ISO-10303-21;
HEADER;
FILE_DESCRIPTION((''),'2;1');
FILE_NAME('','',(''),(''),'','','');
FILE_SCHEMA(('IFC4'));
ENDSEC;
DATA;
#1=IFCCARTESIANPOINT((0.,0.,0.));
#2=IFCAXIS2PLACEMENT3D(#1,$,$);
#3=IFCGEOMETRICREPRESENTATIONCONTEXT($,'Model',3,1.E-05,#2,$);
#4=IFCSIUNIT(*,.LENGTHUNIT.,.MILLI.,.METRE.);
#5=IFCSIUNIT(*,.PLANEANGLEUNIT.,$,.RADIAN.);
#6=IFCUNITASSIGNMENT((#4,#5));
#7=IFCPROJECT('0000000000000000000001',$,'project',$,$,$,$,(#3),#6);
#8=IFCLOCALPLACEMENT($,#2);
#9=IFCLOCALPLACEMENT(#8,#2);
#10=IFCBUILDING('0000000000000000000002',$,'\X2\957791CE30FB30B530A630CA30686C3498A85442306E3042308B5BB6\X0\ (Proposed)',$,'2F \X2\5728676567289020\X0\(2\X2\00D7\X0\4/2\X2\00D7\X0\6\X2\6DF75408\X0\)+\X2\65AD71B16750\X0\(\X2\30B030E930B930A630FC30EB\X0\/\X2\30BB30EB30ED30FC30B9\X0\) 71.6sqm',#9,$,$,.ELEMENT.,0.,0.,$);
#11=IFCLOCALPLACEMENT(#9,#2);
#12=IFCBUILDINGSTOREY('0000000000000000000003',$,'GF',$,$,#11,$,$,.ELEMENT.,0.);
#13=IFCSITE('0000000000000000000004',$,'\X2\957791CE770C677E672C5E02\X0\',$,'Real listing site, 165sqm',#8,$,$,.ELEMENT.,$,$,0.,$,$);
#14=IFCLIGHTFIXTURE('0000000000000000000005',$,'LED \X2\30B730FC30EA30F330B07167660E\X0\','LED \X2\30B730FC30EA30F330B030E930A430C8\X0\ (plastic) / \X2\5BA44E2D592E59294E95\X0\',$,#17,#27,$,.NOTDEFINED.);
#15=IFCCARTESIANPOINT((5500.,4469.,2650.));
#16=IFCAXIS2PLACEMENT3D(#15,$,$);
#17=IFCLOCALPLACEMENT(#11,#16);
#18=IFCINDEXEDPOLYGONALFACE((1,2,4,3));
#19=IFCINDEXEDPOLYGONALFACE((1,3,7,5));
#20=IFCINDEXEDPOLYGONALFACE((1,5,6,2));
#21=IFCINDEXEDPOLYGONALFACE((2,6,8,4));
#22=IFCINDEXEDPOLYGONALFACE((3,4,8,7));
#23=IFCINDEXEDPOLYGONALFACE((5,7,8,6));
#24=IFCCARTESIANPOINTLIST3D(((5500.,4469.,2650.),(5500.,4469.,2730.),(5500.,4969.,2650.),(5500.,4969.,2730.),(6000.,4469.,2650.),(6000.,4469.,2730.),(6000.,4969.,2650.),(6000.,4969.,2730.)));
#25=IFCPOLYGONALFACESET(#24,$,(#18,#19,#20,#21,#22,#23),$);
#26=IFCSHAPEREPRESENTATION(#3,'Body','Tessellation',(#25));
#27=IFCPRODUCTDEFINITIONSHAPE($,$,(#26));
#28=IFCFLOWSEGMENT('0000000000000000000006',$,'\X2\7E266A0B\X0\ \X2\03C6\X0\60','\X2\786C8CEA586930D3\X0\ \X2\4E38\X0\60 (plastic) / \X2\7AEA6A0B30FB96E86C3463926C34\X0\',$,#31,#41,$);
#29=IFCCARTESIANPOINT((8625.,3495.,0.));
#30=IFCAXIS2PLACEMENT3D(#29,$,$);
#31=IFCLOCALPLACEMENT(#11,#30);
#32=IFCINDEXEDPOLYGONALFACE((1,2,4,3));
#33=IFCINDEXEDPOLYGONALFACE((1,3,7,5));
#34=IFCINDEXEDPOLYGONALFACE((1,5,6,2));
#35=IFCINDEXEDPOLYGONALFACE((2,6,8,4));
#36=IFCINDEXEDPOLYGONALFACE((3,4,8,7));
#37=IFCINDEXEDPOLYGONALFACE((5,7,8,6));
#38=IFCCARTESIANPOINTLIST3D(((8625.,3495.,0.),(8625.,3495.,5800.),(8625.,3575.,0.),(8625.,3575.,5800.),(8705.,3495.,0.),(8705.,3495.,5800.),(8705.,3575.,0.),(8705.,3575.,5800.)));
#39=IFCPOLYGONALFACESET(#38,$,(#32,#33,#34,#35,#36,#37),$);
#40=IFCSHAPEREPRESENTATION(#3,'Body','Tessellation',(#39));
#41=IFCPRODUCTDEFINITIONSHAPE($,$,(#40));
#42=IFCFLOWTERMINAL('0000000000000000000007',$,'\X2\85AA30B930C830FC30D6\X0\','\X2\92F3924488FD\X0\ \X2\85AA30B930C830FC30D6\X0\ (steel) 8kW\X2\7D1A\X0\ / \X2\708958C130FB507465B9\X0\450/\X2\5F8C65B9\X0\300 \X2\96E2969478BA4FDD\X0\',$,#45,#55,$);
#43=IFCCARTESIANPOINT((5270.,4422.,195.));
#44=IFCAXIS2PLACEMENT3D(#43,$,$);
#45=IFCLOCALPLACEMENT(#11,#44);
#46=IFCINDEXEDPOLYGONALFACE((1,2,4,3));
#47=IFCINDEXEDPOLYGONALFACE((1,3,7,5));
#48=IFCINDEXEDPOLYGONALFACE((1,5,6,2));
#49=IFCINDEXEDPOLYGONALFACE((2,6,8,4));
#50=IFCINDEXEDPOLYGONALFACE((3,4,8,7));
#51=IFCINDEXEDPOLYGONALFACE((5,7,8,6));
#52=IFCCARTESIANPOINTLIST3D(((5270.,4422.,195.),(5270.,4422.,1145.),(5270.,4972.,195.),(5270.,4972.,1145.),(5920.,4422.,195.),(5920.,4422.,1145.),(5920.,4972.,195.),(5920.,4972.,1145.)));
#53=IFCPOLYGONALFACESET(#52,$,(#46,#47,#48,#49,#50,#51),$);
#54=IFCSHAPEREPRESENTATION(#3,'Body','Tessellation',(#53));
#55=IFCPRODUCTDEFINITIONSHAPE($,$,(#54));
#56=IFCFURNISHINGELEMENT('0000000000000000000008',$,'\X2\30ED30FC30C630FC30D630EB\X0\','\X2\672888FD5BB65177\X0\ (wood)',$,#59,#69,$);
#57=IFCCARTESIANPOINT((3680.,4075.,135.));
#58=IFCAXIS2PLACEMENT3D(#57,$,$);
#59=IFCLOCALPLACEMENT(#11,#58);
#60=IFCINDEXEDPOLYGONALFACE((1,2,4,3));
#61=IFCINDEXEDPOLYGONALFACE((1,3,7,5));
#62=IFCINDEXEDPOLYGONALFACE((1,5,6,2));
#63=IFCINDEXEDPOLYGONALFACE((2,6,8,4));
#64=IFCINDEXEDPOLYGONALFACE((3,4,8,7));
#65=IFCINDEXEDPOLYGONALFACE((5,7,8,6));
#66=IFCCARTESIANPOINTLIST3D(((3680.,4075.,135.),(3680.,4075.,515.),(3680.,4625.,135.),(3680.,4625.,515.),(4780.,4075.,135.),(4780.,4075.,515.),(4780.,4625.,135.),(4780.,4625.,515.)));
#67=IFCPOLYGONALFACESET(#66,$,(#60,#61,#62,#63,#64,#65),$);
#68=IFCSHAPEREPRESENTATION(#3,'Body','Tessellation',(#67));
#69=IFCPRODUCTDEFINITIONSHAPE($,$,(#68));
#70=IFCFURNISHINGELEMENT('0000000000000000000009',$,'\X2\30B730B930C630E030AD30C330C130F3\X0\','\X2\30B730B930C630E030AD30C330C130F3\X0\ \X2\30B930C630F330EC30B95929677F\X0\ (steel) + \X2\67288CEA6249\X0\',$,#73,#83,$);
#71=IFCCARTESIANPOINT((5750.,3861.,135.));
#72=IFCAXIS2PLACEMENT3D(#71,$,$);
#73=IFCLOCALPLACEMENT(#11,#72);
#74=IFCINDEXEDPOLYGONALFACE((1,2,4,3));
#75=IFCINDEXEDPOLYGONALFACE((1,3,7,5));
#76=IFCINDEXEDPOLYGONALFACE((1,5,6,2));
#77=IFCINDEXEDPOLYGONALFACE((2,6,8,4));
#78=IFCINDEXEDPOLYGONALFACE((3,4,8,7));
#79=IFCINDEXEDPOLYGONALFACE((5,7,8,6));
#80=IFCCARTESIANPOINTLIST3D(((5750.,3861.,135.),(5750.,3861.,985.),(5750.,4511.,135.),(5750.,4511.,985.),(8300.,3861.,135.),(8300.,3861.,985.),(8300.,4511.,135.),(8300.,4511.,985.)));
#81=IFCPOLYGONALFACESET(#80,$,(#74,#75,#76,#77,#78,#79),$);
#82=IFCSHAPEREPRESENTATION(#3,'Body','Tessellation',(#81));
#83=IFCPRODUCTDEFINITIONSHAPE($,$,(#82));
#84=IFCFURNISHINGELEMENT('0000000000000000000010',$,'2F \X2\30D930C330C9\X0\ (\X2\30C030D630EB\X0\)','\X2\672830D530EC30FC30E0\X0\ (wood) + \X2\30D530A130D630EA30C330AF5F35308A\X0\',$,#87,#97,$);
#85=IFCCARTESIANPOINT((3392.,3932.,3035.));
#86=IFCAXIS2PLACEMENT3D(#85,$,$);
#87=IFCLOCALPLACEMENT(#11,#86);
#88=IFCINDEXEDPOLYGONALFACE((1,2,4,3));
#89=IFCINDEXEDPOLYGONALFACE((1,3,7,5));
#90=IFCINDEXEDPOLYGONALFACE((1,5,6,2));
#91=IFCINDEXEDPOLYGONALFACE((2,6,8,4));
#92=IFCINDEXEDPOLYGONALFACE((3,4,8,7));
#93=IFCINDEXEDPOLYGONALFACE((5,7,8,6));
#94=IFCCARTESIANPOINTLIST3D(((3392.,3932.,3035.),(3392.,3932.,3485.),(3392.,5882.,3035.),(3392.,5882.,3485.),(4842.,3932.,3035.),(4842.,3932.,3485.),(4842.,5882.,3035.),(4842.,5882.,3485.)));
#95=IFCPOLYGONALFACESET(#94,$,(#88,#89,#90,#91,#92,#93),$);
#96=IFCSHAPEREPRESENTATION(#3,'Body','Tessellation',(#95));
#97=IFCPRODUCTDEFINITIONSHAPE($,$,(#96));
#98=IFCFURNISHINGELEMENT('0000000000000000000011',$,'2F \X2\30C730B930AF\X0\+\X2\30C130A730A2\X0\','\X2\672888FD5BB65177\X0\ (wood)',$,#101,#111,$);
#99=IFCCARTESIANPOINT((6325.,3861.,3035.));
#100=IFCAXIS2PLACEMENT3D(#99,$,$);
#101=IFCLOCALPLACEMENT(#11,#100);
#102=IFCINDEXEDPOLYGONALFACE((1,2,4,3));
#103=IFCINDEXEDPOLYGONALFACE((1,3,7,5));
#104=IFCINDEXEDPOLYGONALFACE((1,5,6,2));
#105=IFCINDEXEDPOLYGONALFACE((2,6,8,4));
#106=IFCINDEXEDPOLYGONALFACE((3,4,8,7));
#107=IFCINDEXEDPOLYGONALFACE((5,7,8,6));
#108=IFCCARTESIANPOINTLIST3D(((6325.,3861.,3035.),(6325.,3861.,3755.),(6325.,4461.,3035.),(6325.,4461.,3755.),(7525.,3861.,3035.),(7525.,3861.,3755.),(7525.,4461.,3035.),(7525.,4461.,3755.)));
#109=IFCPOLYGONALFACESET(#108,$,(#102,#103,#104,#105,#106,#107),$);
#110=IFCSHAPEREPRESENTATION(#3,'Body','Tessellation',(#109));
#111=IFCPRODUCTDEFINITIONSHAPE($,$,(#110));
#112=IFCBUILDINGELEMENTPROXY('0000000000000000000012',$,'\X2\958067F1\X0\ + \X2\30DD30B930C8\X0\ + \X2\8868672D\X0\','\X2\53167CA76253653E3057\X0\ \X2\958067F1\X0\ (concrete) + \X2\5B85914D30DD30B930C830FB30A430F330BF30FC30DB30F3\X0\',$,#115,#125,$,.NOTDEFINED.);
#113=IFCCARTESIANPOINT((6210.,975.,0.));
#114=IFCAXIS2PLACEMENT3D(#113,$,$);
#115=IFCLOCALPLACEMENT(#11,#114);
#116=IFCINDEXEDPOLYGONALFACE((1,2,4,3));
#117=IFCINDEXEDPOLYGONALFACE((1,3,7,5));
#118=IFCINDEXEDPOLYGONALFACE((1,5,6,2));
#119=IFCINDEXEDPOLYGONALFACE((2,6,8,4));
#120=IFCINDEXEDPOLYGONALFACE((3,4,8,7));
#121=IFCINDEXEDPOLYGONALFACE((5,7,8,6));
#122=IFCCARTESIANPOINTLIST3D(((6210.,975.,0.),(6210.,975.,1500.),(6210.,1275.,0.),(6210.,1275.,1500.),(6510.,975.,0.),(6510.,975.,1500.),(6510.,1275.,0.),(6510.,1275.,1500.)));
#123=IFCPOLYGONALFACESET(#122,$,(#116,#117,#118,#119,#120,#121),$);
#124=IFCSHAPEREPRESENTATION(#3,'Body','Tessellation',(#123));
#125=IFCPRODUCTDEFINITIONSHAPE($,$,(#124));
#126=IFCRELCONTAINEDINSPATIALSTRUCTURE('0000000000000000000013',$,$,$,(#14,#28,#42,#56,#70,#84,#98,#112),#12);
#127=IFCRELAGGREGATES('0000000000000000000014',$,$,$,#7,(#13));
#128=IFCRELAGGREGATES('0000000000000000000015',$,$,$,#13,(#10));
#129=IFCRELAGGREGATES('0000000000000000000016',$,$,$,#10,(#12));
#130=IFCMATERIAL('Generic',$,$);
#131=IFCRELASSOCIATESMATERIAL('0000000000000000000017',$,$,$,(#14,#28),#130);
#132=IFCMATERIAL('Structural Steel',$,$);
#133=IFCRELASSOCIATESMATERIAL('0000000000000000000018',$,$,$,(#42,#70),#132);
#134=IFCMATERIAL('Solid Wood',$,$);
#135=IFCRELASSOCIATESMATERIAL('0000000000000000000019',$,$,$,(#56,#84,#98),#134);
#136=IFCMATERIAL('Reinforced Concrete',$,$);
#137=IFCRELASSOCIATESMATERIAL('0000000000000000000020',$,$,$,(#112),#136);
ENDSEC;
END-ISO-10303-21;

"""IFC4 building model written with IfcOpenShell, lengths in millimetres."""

from ifc_helpers import new_model, si_unit, frame, frame_2d, origin, place, context, project, spatial, rectangle, extrude, material, element, save


model = new_model("IFC4")

# Units and contexts
model_context = context("Model", 3, precision=1e-05, world=origin())
ifc_project = project(units=[si_unit("LENGTHUNIT", "METRE", prefix="MILLI"), si_unit("PLANEANGLEUNIT", "RADIAN")], contexts=[model_context])

# Site, building, storey
site_placement = place(None, origin())
site = spatial("IfcSite", under=ifc_project, at=site_placement, Name="長野県松本市", ObjectType="Real listing site, 165sqm", CompositionType="ELEMENT", RefElevation=0.0)
building_placement = place(site_placement, origin())
building = spatial("IfcBuilding", under=site, at=building_placement, Name="長野・サウナと水風呂のある家 (Proposed)", ObjectType="2F 在来木造(2×4/2×6混合)+断熱材(グラスウール/セルロース) 71.6sqm", CompositionType="ELEMENT", ElevationOfRefHeight=0.0, ElevationOfTerrain=0.0)
storey_placement = place(building_placement, origin())
storey = spatial("IfcBuildingStorey", under=building, at=storey_placement, Name="GF", CompositionType="ELEMENT", Elevation=0.0)

# Shared definitions
ifc_material_1 = material(Name="Solid Wood")

# Shared definitions
ifc_material_2 = material(Name="Reinforced Concrete")

# Shared definitions
ifc_material_3 = material(Name="Structural Steel")

# Shared definitions
ifc_material_4 = material(Name="Generic")

# Light fixture
light_fixture_placement = place(storey_placement, frame((5500.0, 4469.0, 2650.0)))
element("IfcLightFixture", 1, at=light_fixture_placement, inside=storey, material=ifc_material_4, Name="LED シーリング照明", Description="LED シーリングライト (plastic) / 室中央天井", PredefinedType="NOTDEFINED", context=model_context, shape_type="SweptSolid", body=[
    extrude(rectangle(XDim=500.0, YDim=500.0, at=frame_2d((250.0, 250.0))), frame((5500.0, 4469.0, 2650.0)), (0.0, 0.0, 1.0), 80.0),
])

# Flow segment
flow_segment_placement = place(storey_placement, frame((8625.0, 3495.0, 0.0)))
element("IfcFlowSegment", 2, at=flow_segment_placement, inside=storey, material=ifc_material_4, Name="縦樋 φ60", Description="硬質塩ビ 丸60 (plastic) / 竪樋・雨水排水", context=model_context, shape_type="SweptSolid", body=[
    extrude(rectangle(XDim=80.0, YDim=80.0, at=frame_2d((40.0, 40.0))), frame((8625.0, 3495.0, 0.0)), (0.0, 0.0, 1.0), 5800.0),
])

# Flow terminal
flow_terminal_1_placement = place(storey_placement, frame((5270.0, 4422.0, 195.0)))
element("IfcFlowTerminal", 3, at=flow_terminal_1_placement, inside=storey, material=ifc_material_3, Name="薪ストーブ", Description="鋳鉄製 薪ストーブ (steel) 8kW級 / 炉壁・側方450/後方300 離隔確保", context=model_context, shape_type="SweptSolid", body=[
    extrude(rectangle(XDim=650.0, YDim=550.0, at=frame_2d((325.0, 275.0))), frame((5270.0, 4422.0, 195.0)), (0.0, 0.0, 1.0), 950.0),
])

# Furnishing elements
furnishing_1_placement = place(storey_placement, frame((3680.0, 4075.0, 135.0)))
element("IfcFurnishingElement", 4, at=furnishing_1_placement, inside=storey, material=ifc_material_1, Name="ローテーブル", Description="木製家具 (wood)", context=model_context, shape_type="SweptSolid", body=[
    extrude(rectangle(XDim=1100.0, YDim=550.0, at=frame_2d((550.0, 275.0))), frame((3680.0, 4075.0, 135.0)), (0.0, 0.0, 1.0), 380.0),
])
furnishing_2_placement = place(storey_placement, frame((5750.0, 3861.0, 135.0)))
element("IfcFurnishingElement", 5, at=furnishing_2_placement, inside=storey, material=ifc_material_3, Name="システムキッチン", Description="システムキッチン ステンレス天板 (steel) + 木質扉", context=model_context, shape_type="SweptSolid", body=[
    extrude(rectangle(XDim=2550.0, YDim=650.0, at=frame_2d((1275.0, 325.0))), frame((5750.0, 3861.0, 135.0)), (0.0, 0.0, 1.0), 850.0),
])
furnishing_3_placement = place(storey_placement, frame((3392.0, 3932.0, 3035.0)))
element("IfcFurnishingElement", 6, at=furnishing_3_placement, inside=storey, material=ifc_material_1, Name="2F ベッド (ダブル)", Description="木フレーム (wood) + ファブリック張り", context=model_context, shape_type="SweptSolid", body=[
    extrude(rectangle(XDim=1450.0, YDim=1950.0, at=frame_2d((725.0, 975.0))), frame((3392.0, 3932.0, 3035.0)), (0.0, 0.0, 1.0), 450.0),
])
furnishing_4_placement = place(storey_placement, frame((6325.0, 3861.0, 3035.0)))
element("IfcFurnishingElement", 7, at=furnishing_4_placement, inside=storey, material=ifc_material_1, Name="2F デスク+チェア", Description="木製家具 (wood)", context=model_context, shape_type="SweptSolid", body=[
    extrude(rectangle(XDim=1200.0, YDim=600.0, at=frame_2d((600.0, 300.0))), frame((6325.0, 3861.0, 3035.0)), (0.0, 0.0, 1.0), 720.0),
])

# Building element proxy
proxy_placement = place(storey_placement, frame((6210.0, 975.0, 0.0)))
element("IfcBuildingElementProxy", 8, at=proxy_placement, inside=storey, material=ifc_material_2, Name="門柱 + ポスト + 表札", Description="化粧打放し 門柱 (concrete) + 宅配ポスト・インターホン", PredefinedType="NOTDEFINED", context=model_context, shape_type="SweptSolid", body=[
    extrude(rectangle(XDim=300.0, YDim=300.0, at=frame_2d((150.0, 150.0))), frame((6210.0, 975.0, 0.0)), (0.0, 0.0, 1.0), 1500.0),
])

save(model, "model.ifc")
